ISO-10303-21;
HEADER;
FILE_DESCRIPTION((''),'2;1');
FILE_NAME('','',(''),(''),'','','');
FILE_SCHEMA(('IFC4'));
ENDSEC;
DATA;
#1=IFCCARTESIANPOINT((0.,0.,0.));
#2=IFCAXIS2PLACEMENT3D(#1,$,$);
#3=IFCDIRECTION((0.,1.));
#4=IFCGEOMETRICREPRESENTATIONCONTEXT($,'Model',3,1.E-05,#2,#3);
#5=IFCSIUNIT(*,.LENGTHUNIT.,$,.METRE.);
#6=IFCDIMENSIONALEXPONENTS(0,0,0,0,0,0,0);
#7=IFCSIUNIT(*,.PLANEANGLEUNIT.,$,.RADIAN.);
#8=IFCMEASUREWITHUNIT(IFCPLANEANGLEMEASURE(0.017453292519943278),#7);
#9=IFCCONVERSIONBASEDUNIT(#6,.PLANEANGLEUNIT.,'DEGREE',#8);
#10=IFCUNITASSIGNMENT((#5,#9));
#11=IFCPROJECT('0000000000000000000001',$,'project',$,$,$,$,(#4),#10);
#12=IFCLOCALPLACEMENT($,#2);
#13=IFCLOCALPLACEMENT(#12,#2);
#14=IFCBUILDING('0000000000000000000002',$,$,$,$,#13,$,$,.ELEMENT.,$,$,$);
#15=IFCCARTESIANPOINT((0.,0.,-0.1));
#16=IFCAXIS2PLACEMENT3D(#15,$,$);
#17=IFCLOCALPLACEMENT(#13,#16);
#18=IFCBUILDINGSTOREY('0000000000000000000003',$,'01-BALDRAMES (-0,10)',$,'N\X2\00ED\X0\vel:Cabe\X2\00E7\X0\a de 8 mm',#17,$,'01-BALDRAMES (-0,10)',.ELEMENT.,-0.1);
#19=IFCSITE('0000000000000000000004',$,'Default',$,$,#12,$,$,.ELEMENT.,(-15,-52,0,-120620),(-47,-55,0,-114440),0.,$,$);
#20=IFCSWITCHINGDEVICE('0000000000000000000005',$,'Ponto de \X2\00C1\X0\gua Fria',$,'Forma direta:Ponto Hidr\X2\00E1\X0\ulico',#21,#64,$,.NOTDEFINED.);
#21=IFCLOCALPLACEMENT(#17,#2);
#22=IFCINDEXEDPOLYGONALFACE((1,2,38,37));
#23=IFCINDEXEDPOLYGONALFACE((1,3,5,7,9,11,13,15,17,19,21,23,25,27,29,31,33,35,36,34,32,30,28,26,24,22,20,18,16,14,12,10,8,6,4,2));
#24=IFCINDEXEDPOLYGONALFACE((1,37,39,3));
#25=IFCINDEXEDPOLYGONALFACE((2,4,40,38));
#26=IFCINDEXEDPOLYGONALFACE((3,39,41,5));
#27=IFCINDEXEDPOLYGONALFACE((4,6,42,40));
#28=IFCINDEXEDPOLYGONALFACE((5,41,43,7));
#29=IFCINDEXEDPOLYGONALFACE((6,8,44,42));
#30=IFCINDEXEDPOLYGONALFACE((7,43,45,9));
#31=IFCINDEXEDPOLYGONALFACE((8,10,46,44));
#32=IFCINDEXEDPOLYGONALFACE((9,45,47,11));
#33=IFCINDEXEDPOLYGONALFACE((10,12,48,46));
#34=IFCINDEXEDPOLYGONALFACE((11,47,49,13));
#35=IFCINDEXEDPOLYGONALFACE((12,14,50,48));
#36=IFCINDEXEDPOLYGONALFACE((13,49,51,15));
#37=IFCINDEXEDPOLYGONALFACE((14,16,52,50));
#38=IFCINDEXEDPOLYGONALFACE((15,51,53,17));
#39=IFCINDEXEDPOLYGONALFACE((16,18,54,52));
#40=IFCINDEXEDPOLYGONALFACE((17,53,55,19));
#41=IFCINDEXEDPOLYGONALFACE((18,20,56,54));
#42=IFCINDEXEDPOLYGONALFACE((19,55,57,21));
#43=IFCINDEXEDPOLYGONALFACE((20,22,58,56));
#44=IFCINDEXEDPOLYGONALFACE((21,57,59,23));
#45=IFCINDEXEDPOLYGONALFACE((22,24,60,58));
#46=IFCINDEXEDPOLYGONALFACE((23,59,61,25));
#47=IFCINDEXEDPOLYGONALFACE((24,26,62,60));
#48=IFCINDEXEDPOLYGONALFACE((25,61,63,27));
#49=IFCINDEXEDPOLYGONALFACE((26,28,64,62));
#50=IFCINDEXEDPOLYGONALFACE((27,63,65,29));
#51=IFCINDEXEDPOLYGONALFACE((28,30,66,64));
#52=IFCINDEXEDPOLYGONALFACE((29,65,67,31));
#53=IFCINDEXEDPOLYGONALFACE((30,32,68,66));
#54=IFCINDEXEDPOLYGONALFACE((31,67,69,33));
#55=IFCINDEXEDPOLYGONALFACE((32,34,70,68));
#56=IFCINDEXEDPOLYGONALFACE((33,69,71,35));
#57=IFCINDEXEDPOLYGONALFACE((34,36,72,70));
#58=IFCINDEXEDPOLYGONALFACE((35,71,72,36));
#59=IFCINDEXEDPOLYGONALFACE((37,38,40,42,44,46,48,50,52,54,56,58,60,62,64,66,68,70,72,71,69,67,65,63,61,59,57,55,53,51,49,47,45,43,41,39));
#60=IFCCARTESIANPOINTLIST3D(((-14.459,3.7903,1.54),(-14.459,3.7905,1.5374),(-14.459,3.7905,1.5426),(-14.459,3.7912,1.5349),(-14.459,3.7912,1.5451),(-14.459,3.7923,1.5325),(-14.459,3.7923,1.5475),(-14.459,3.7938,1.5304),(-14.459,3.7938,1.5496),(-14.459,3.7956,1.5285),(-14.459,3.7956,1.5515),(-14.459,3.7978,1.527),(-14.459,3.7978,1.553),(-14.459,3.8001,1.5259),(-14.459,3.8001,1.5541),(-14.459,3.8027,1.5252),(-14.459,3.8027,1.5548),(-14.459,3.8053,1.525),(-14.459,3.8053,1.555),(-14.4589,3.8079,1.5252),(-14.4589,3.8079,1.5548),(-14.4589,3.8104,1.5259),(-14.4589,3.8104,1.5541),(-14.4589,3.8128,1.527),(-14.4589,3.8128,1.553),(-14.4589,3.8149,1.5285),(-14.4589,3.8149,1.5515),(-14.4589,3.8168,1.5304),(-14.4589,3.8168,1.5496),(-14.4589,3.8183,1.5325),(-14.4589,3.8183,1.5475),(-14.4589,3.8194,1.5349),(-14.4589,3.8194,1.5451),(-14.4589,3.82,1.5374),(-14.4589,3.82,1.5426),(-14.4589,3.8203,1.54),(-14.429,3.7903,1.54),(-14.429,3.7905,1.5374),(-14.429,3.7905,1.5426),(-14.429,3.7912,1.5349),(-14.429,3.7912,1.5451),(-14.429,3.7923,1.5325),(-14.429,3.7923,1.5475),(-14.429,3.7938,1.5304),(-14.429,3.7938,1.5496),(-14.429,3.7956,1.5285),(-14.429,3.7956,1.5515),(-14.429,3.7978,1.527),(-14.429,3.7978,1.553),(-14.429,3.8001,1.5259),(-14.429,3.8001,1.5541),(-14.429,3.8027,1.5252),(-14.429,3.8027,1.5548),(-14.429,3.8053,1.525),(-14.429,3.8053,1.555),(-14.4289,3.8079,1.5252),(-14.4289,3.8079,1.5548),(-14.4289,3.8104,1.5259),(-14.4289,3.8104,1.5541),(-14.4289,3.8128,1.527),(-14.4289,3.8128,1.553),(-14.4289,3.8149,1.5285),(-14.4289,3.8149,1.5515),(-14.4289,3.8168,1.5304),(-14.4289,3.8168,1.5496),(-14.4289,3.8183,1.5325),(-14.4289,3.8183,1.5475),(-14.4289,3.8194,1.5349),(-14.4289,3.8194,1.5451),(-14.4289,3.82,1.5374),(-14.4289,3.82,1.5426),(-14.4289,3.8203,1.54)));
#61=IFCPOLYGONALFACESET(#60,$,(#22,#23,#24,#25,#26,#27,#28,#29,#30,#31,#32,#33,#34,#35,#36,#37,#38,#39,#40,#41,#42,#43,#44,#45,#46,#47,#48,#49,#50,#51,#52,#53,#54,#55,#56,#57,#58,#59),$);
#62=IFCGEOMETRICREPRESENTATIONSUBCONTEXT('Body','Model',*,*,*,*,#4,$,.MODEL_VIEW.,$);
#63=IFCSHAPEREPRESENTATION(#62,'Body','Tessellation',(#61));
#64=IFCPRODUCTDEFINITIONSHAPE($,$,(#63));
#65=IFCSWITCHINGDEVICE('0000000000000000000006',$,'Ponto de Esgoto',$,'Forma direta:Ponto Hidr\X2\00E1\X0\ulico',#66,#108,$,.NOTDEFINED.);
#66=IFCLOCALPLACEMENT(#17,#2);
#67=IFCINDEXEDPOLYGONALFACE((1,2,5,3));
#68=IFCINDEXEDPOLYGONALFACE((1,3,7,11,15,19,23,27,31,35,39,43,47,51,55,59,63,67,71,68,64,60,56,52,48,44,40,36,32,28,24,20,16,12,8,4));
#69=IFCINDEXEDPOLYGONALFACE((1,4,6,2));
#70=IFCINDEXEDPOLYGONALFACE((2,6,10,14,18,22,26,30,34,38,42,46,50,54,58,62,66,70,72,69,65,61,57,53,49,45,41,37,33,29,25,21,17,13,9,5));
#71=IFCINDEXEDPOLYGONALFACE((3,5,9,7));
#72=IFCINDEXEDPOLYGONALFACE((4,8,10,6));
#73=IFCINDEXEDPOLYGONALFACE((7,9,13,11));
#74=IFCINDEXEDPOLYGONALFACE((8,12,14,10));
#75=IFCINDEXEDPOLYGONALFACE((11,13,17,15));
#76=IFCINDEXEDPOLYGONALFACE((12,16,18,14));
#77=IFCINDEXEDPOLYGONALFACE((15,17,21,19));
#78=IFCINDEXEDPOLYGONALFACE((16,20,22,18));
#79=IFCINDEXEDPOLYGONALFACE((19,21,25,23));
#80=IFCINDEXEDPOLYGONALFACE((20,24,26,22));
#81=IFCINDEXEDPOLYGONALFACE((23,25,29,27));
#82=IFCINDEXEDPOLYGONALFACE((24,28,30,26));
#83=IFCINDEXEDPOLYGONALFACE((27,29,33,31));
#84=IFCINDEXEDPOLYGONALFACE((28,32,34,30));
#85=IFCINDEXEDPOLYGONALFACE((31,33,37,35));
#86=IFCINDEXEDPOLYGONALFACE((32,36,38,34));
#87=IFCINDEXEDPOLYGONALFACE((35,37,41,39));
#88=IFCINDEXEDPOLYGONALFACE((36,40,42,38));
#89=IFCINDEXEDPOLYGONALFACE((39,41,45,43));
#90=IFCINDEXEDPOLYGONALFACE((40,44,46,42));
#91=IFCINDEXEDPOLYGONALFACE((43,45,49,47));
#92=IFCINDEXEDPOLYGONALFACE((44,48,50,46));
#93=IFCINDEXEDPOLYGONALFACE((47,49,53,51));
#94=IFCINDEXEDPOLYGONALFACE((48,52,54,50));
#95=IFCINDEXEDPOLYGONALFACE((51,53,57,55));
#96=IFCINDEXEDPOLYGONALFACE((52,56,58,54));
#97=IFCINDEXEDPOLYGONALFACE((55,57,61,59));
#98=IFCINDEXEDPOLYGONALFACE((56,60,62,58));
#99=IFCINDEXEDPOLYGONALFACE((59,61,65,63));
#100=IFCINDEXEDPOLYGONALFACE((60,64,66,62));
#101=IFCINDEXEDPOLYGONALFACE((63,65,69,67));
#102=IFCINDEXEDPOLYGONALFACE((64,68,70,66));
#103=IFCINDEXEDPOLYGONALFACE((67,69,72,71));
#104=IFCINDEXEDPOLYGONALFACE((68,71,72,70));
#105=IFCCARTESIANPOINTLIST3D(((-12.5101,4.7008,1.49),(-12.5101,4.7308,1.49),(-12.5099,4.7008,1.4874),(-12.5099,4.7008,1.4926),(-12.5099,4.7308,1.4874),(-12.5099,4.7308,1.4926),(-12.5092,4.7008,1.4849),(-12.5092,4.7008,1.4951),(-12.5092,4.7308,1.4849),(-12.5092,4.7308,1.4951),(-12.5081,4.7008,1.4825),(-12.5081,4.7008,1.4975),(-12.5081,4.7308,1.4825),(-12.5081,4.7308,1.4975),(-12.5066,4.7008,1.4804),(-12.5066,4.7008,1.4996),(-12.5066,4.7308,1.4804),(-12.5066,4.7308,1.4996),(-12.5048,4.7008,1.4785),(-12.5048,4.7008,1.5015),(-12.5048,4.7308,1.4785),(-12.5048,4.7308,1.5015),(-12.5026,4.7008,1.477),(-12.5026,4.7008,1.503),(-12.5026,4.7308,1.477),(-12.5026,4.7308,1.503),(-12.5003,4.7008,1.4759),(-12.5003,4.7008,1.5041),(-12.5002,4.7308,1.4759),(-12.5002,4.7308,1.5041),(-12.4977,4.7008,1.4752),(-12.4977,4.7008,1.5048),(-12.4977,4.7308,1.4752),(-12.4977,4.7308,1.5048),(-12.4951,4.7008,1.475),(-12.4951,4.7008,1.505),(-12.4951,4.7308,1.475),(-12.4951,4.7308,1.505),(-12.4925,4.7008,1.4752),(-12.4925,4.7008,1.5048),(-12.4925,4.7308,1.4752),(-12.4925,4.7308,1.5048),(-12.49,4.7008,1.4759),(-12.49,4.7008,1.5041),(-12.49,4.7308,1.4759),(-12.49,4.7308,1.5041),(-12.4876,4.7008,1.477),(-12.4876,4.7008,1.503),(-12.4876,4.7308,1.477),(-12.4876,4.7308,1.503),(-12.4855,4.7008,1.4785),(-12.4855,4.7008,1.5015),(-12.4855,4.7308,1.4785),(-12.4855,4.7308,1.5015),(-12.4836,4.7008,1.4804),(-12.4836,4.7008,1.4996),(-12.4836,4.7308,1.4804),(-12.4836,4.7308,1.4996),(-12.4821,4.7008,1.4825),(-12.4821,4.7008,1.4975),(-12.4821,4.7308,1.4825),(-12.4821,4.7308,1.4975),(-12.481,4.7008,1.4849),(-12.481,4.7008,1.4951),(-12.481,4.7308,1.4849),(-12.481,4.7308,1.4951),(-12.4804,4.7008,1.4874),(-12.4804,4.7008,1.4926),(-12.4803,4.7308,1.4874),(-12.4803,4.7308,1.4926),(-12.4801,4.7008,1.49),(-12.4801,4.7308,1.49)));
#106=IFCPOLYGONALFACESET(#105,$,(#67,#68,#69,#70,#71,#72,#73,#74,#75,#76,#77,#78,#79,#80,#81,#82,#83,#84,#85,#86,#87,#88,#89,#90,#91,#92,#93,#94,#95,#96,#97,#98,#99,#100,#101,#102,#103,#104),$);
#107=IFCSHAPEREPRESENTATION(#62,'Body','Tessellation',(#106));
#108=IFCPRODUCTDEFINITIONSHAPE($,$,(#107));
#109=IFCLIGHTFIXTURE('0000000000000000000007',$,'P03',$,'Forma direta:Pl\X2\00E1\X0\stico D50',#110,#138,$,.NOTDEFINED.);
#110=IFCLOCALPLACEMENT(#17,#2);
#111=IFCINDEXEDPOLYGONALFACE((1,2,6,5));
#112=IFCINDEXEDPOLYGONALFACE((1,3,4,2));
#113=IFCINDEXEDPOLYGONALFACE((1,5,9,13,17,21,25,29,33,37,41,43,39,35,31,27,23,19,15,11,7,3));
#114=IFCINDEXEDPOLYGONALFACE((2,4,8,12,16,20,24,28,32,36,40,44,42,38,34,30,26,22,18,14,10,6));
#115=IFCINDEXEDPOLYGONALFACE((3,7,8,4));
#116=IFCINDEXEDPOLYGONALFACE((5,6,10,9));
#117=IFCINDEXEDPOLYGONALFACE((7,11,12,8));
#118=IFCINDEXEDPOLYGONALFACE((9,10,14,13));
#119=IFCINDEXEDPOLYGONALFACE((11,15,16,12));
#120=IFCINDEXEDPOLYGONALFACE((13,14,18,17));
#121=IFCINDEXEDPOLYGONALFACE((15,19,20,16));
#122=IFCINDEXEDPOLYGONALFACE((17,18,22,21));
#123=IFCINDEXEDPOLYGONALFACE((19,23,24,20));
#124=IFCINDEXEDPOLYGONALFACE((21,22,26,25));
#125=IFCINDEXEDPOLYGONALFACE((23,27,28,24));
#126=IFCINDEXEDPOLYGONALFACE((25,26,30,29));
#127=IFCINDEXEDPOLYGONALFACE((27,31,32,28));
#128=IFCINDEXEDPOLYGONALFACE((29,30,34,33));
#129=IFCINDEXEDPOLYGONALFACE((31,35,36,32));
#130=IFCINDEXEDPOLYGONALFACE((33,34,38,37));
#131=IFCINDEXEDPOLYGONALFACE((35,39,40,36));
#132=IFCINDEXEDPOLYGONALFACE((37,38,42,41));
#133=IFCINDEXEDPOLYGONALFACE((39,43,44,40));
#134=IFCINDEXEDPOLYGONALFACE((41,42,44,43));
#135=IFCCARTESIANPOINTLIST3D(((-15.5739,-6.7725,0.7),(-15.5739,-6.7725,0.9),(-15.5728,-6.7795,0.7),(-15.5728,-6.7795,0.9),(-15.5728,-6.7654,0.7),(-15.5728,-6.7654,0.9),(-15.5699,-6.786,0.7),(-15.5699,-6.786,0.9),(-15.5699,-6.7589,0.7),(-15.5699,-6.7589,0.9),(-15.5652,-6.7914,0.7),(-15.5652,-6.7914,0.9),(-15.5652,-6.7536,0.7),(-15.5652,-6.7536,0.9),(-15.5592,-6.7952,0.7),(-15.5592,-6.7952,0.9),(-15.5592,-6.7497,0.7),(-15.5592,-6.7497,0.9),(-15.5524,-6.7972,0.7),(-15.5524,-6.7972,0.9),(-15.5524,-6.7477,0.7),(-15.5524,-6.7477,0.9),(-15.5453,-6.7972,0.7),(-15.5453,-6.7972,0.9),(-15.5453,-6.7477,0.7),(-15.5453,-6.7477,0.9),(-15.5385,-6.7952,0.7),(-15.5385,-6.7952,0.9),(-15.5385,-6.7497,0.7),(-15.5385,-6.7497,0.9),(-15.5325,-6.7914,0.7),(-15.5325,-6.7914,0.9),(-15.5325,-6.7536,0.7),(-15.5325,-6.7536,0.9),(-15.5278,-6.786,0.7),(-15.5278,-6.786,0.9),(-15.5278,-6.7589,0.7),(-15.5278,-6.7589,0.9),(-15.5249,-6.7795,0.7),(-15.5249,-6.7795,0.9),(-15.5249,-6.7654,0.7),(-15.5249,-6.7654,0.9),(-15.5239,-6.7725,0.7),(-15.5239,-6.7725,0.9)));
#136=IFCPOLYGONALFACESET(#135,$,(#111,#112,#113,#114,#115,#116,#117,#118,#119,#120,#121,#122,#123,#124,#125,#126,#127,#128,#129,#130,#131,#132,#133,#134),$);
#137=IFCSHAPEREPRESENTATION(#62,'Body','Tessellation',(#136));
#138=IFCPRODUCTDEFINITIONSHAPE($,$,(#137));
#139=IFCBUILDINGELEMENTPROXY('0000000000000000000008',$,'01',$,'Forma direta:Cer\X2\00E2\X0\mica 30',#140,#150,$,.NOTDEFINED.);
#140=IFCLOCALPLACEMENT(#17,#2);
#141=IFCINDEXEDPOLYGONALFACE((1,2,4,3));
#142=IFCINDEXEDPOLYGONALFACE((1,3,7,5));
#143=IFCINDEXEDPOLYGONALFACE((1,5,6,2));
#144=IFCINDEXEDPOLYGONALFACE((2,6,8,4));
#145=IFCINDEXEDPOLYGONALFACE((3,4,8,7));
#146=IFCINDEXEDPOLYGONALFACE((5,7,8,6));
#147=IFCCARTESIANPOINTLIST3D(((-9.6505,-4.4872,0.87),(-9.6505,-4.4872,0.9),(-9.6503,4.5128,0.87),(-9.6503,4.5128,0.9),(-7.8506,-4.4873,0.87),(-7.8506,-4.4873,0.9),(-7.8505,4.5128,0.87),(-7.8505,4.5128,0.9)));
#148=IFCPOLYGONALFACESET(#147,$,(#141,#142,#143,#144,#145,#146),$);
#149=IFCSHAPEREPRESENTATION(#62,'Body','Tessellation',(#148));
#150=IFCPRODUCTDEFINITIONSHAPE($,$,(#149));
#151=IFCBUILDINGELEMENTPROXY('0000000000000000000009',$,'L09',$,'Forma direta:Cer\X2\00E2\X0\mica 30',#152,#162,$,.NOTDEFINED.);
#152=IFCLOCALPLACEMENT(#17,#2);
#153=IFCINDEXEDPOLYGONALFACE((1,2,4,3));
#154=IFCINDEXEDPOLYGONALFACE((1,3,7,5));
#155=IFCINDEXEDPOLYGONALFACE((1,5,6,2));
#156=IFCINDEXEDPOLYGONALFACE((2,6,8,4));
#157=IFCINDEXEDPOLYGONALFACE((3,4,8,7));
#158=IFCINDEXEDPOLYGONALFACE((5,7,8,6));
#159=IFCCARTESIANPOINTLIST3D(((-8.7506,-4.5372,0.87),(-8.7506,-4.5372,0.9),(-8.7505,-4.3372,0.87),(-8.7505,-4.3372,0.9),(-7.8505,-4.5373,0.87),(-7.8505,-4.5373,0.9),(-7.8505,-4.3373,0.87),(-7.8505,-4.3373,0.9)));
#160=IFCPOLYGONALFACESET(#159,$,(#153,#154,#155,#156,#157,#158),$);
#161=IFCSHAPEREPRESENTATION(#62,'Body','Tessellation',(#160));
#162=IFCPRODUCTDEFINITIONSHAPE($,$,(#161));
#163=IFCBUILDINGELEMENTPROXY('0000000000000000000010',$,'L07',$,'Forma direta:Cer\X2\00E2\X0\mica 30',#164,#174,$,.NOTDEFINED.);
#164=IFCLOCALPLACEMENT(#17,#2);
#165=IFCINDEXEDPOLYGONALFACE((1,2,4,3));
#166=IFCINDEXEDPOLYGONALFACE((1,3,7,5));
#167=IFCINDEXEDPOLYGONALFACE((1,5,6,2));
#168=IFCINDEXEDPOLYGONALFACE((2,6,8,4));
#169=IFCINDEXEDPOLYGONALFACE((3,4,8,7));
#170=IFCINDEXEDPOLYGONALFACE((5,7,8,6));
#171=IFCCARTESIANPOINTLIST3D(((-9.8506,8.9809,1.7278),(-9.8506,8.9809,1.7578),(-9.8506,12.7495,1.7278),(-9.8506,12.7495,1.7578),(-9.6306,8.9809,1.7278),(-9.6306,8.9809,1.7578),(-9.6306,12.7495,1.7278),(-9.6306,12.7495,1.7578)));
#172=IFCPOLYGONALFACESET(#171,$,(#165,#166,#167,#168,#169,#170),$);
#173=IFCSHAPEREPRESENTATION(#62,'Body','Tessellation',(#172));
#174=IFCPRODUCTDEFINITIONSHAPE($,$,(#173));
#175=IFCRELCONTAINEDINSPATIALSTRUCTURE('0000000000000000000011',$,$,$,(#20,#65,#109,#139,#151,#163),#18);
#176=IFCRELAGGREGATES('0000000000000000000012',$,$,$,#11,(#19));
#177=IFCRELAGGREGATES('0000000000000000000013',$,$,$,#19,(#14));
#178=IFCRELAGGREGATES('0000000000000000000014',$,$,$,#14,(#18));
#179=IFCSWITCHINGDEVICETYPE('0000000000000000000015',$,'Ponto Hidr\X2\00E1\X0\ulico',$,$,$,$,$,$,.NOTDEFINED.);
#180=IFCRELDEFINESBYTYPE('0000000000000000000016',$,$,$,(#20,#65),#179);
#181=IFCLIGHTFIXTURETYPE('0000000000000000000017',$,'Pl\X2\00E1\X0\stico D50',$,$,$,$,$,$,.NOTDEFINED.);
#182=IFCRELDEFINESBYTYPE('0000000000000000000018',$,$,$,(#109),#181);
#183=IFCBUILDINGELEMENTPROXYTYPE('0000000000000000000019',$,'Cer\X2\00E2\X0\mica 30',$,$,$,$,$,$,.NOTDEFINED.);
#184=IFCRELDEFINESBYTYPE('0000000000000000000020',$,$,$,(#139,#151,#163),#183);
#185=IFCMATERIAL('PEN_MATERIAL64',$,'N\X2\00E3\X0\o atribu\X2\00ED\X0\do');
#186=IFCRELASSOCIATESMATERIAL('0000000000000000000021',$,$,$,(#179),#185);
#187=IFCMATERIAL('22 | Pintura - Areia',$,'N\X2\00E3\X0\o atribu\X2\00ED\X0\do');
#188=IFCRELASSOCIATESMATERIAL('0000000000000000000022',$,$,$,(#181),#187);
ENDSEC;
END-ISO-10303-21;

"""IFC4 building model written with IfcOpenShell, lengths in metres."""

from ifc_helpers import new_model, entity, si_unit, converted_unit, direction, frame, origin, place, context, subcontext, project, spatial, arc, indexed_curve, outline, extrude, material, type_object, element, save


model = new_model("IFC4")

# Units and contexts
model_context = context("Model", 3, precision=1e-05, world=origin(), true_north=direction((0.0, 1.0)))
body_context = subcontext(model_context, "Body", "Model", "MODEL_VIEW")
ifc_project = project(units=[si_unit("LENGTHUNIT", "METRE"), converted_unit("PLANEANGLEUNIT", "DEGREE", entity("IfcPlaneAngleMeasure", 0.017453292519943278), si_unit("PLANEANGLEUNIT", "RADIAN"), dimensions=[0, 0, 0, 0, 0, 0, 0])], contexts=[model_context])

# Site, building, storey
site_placement = place(None, origin())
site = spatial("IfcSite", under=ifc_project, at=site_placement, Name="Default", CompositionType="ELEMENT", RefLatitude=(-15, -52, 0, -120620), RefLongitude=(-47, -55, 0, -114440), RefElevation=0.0)
building_placement = place(site_placement, origin())
building = spatial("IfcBuilding", under=site, at=building_placement, CompositionType="ELEMENT")
storey_placement = place(building_placement, frame((0.0, 0.0, -0.1)))
storey = spatial("IfcBuildingStorey", under=building, at=storey_placement, Name="01-BALDRAMES (-0,10)", ObjectType="Nível:Cabeça de 8 mm", LongName="01-BALDRAMES (-0,10)", CompositionType="ELEMENT", Elevation=-0.1)

# Shared definitions
ifc_material_1 = material(Name="22 | Pintura - Areia", Category="Não atribuído")

# Switching devices
ifc_material_2 = material(Name="PEN_MATERIAL64", Category="Não atribuído")
switching_device_type_1 = type_object("IfcSwitchingDeviceType", Name="Ponto Hidráulico", PredefinedType="NOTDEFINED", material=ifc_material_2)
switching_device_1_placement = place(storey_placement, origin())
element("IfcSwitchingDevice", 1, at=switching_device_1_placement, inside=storey, type_object=switching_device_type_1, Name="Ponto de Água Fria", ObjectType="Forma direta:Ponto Hidráulico", PredefinedType="NOTDEFINED", context=body_context, shape_type="SweptSolid", body=[
    extrude(outline(indexed_curve([(-0.0013, -0.0149), (0.0013, -0.0149), (0.0039, -0.0145), (0.0063, -0.0136), (0.0086, -0.0123), (0.0106, -0.0106), (0.0123, -0.0086), (0.0136, -0.0063), (0.0145, -0.0039), (0.0149, -0.0013), (0.0149, 0.0013), (0.0145, 0.0039), (0.0136, 0.0063), (0.0123, 0.0086), (0.0106, 0.0106), (0.0086, 0.0123), (0.0063, 0.0136), (0.0039, 0.0145), (0.0013, 0.0149), (-0.0013, 0.0149), (-0.0039, 0.0145), (-0.0063, 0.0136), (-0.0086, 0.0123), (-0.0106, 0.0106), (-0.0123, 0.0086), (-0.0136, 0.0063), (-0.0145, 0.0039), (-0.0149, 0.0013), (-0.0149, -0.0013), (-0.0145, -0.0039), (-0.0136, -0.0063), (-0.0123, -0.0086), (-0.0106, -0.0106), (-0.0086, -0.0123), (-0.0063, -0.0136), (-0.0039, -0.0145), (-0.0013, -0.0149)], self_intersect=False)), frame((-14.459, 3.8053, 1.54), z_axis=(1.0, -0.000299, 0.0), x_axis=(0.000289, 0.965926, 0.258819)), (0.0, 0.0, 1.0), 0.03),
])
switching_device_2_placement = place(storey_placement, origin())
element("IfcSwitchingDevice", 2, at=switching_device_2_placement, inside=storey, type_object=switching_device_type_1, Name="Ponto de Esgoto", ObjectType="Forma direta:Ponto Hidráulico", PredefinedType="NOTDEFINED", context=body_context, shape_type="SweptSolid", body=[
    extrude(outline(indexed_curve([(-0.0013, -0.0149), (0.0013, -0.0149), (0.0039, -0.0145), (0.0063, -0.0136), (0.0086, -0.0123), (0.0106, -0.0106), (0.0123, -0.0086), (0.0136, -0.0063), (0.0145, -0.0039), (0.0149, -0.0013), (0.0149, 0.0013), (0.0145, 0.0039), (0.0136, 0.0063), (0.0123, 0.0086), (0.0106, 0.0106), (0.0086, 0.0123), (0.0063, 0.0136), (0.0039, 0.0145), (0.0013, 0.0149), (-0.0013, 0.0149), (-0.0039, 0.0145), (-0.0063, 0.0136), (-0.0086, 0.0123), (-0.0106, 0.0106), (-0.0123, 0.0086), (-0.0136, 0.0063), (-0.0145, 0.0039), (-0.0149, 0.0013), (-0.0149, -0.0013), (-0.0145, -0.0039), (-0.0136, -0.0063), (-0.0123, -0.0086), (-0.0106, -0.0106), (-0.0086, -0.0123), (-0.0063, -0.0136), (-0.0039, -0.0145), (-0.0013, -0.0149)], self_intersect=False)), frame((-12.4951, 4.7008, 1.49), z_axis=(0.000299, 1.0, 0.0), x_axis=(-0.996195, 0.000298, -0.087156)), (0.0, 0.0, 1.0), 0.03),
])

# Light fixture
light_fixture_type_1 = type_object("IfcLightFixtureType", Name="Plástico D50", PredefinedType="NOTDEFINED", material=ifc_material_1)
light_fixture_1_placement = place(storey_placement, origin())
element("IfcLightFixture", 3, at=light_fixture_1_placement, inside=storey, type_object=light_fixture_type_1, Name="P03", ObjectType="Forma direta:Plástico D50", PredefinedType="NOTDEFINED", context=body_context, shape_type="SweptSolid", body=[
    extrude(outline(indexed_curve([(0.025, 0.0), (0.0, 0.025), (-0.025, 0.0), (0.0, -0.025)], segments=[arc(1, 2, 3), arc(3, 4, 1)], self_intersect=False)), frame((-15.5489, -6.7725, 0.7)), (0.0, 0.0, 1.0), 0.2),
])

# Building element proxies
building_element_proxy_type_1 = type_object("IfcBuildingElementProxyType", Name="Cerâmica 30", PredefinedType="NOTDEFINED")
proxy_1_placement = place(storey_placement, origin())
element("IfcBuildingElementProxy", 4, at=proxy_1_placement, inside=storey, type_object=building_element_proxy_type_1, Name="01", ObjectType="Forma direta:Cerâmica 30", PredefinedType="NOTDEFINED", context=body_context, shape_type="SweptSolid", body=[
    extrude(outline(indexed_curve([(-4.5, -0.8999), (4.5, -0.8999), (4.5, 0.8999), (-4.5, 0.8999), (-4.5, -0.8999)], self_intersect=False)), frame((-8.7505, 0.0128, 0.87), z_axis=(0.0, 0.0, 1.0), x_axis=(0.000013, 1.0, 0.0)), (0.0, 0.0, 1.0), 0.03),
])
proxy_2_placement = place(storey_placement, origin())
element("IfcBuildingElementProxy", 5, at=proxy_2_placement, inside=storey, type_object=building_element_proxy_type_1, Name="L09", ObjectType="Forma direta:Cerâmica 30", PredefinedType="NOTDEFINED", context=body_context, shape_type="SweptSolid", body=[
    extrude(outline(indexed_curve([(-0.1, -0.45), (0.1, -0.45), (0.1, 0.45), (-0.1, 0.45), (-0.1, -0.45)], self_intersect=False)), frame((-8.3005, -4.4373, 0.87), z_axis=(0.0, 0.0, 1.0), x_axis=(0.000013, 1.0, 0.0)), (0.0, 0.0, 1.0), 0.03),
])
proxy_3_placement = place(storey_placement, origin())
element("IfcBuildingElementProxy", 6, at=proxy_3_placement, inside=storey, type_object=building_element_proxy_type_1, Name="L07", ObjectType="Forma direta:Cerâmica 30", PredefinedType="NOTDEFINED", context=body_context, shape_type="SweptSolid", body=[
    extrude(outline(indexed_curve([(-1.8843, -0.11), (1.8843, -0.11), (1.8843, 0.11), (-1.8843, 0.11), (-1.8843, -0.11)], self_intersect=False)), frame((-9.7406, 10.8652, 1.7278), z_axis=(0.0, 0.0, 1.0), x_axis=(-0.000006, 1.0, 0.0)), (0.0, 0.0, 1.0), 0.03),
])

save(model, "model.ifc")
